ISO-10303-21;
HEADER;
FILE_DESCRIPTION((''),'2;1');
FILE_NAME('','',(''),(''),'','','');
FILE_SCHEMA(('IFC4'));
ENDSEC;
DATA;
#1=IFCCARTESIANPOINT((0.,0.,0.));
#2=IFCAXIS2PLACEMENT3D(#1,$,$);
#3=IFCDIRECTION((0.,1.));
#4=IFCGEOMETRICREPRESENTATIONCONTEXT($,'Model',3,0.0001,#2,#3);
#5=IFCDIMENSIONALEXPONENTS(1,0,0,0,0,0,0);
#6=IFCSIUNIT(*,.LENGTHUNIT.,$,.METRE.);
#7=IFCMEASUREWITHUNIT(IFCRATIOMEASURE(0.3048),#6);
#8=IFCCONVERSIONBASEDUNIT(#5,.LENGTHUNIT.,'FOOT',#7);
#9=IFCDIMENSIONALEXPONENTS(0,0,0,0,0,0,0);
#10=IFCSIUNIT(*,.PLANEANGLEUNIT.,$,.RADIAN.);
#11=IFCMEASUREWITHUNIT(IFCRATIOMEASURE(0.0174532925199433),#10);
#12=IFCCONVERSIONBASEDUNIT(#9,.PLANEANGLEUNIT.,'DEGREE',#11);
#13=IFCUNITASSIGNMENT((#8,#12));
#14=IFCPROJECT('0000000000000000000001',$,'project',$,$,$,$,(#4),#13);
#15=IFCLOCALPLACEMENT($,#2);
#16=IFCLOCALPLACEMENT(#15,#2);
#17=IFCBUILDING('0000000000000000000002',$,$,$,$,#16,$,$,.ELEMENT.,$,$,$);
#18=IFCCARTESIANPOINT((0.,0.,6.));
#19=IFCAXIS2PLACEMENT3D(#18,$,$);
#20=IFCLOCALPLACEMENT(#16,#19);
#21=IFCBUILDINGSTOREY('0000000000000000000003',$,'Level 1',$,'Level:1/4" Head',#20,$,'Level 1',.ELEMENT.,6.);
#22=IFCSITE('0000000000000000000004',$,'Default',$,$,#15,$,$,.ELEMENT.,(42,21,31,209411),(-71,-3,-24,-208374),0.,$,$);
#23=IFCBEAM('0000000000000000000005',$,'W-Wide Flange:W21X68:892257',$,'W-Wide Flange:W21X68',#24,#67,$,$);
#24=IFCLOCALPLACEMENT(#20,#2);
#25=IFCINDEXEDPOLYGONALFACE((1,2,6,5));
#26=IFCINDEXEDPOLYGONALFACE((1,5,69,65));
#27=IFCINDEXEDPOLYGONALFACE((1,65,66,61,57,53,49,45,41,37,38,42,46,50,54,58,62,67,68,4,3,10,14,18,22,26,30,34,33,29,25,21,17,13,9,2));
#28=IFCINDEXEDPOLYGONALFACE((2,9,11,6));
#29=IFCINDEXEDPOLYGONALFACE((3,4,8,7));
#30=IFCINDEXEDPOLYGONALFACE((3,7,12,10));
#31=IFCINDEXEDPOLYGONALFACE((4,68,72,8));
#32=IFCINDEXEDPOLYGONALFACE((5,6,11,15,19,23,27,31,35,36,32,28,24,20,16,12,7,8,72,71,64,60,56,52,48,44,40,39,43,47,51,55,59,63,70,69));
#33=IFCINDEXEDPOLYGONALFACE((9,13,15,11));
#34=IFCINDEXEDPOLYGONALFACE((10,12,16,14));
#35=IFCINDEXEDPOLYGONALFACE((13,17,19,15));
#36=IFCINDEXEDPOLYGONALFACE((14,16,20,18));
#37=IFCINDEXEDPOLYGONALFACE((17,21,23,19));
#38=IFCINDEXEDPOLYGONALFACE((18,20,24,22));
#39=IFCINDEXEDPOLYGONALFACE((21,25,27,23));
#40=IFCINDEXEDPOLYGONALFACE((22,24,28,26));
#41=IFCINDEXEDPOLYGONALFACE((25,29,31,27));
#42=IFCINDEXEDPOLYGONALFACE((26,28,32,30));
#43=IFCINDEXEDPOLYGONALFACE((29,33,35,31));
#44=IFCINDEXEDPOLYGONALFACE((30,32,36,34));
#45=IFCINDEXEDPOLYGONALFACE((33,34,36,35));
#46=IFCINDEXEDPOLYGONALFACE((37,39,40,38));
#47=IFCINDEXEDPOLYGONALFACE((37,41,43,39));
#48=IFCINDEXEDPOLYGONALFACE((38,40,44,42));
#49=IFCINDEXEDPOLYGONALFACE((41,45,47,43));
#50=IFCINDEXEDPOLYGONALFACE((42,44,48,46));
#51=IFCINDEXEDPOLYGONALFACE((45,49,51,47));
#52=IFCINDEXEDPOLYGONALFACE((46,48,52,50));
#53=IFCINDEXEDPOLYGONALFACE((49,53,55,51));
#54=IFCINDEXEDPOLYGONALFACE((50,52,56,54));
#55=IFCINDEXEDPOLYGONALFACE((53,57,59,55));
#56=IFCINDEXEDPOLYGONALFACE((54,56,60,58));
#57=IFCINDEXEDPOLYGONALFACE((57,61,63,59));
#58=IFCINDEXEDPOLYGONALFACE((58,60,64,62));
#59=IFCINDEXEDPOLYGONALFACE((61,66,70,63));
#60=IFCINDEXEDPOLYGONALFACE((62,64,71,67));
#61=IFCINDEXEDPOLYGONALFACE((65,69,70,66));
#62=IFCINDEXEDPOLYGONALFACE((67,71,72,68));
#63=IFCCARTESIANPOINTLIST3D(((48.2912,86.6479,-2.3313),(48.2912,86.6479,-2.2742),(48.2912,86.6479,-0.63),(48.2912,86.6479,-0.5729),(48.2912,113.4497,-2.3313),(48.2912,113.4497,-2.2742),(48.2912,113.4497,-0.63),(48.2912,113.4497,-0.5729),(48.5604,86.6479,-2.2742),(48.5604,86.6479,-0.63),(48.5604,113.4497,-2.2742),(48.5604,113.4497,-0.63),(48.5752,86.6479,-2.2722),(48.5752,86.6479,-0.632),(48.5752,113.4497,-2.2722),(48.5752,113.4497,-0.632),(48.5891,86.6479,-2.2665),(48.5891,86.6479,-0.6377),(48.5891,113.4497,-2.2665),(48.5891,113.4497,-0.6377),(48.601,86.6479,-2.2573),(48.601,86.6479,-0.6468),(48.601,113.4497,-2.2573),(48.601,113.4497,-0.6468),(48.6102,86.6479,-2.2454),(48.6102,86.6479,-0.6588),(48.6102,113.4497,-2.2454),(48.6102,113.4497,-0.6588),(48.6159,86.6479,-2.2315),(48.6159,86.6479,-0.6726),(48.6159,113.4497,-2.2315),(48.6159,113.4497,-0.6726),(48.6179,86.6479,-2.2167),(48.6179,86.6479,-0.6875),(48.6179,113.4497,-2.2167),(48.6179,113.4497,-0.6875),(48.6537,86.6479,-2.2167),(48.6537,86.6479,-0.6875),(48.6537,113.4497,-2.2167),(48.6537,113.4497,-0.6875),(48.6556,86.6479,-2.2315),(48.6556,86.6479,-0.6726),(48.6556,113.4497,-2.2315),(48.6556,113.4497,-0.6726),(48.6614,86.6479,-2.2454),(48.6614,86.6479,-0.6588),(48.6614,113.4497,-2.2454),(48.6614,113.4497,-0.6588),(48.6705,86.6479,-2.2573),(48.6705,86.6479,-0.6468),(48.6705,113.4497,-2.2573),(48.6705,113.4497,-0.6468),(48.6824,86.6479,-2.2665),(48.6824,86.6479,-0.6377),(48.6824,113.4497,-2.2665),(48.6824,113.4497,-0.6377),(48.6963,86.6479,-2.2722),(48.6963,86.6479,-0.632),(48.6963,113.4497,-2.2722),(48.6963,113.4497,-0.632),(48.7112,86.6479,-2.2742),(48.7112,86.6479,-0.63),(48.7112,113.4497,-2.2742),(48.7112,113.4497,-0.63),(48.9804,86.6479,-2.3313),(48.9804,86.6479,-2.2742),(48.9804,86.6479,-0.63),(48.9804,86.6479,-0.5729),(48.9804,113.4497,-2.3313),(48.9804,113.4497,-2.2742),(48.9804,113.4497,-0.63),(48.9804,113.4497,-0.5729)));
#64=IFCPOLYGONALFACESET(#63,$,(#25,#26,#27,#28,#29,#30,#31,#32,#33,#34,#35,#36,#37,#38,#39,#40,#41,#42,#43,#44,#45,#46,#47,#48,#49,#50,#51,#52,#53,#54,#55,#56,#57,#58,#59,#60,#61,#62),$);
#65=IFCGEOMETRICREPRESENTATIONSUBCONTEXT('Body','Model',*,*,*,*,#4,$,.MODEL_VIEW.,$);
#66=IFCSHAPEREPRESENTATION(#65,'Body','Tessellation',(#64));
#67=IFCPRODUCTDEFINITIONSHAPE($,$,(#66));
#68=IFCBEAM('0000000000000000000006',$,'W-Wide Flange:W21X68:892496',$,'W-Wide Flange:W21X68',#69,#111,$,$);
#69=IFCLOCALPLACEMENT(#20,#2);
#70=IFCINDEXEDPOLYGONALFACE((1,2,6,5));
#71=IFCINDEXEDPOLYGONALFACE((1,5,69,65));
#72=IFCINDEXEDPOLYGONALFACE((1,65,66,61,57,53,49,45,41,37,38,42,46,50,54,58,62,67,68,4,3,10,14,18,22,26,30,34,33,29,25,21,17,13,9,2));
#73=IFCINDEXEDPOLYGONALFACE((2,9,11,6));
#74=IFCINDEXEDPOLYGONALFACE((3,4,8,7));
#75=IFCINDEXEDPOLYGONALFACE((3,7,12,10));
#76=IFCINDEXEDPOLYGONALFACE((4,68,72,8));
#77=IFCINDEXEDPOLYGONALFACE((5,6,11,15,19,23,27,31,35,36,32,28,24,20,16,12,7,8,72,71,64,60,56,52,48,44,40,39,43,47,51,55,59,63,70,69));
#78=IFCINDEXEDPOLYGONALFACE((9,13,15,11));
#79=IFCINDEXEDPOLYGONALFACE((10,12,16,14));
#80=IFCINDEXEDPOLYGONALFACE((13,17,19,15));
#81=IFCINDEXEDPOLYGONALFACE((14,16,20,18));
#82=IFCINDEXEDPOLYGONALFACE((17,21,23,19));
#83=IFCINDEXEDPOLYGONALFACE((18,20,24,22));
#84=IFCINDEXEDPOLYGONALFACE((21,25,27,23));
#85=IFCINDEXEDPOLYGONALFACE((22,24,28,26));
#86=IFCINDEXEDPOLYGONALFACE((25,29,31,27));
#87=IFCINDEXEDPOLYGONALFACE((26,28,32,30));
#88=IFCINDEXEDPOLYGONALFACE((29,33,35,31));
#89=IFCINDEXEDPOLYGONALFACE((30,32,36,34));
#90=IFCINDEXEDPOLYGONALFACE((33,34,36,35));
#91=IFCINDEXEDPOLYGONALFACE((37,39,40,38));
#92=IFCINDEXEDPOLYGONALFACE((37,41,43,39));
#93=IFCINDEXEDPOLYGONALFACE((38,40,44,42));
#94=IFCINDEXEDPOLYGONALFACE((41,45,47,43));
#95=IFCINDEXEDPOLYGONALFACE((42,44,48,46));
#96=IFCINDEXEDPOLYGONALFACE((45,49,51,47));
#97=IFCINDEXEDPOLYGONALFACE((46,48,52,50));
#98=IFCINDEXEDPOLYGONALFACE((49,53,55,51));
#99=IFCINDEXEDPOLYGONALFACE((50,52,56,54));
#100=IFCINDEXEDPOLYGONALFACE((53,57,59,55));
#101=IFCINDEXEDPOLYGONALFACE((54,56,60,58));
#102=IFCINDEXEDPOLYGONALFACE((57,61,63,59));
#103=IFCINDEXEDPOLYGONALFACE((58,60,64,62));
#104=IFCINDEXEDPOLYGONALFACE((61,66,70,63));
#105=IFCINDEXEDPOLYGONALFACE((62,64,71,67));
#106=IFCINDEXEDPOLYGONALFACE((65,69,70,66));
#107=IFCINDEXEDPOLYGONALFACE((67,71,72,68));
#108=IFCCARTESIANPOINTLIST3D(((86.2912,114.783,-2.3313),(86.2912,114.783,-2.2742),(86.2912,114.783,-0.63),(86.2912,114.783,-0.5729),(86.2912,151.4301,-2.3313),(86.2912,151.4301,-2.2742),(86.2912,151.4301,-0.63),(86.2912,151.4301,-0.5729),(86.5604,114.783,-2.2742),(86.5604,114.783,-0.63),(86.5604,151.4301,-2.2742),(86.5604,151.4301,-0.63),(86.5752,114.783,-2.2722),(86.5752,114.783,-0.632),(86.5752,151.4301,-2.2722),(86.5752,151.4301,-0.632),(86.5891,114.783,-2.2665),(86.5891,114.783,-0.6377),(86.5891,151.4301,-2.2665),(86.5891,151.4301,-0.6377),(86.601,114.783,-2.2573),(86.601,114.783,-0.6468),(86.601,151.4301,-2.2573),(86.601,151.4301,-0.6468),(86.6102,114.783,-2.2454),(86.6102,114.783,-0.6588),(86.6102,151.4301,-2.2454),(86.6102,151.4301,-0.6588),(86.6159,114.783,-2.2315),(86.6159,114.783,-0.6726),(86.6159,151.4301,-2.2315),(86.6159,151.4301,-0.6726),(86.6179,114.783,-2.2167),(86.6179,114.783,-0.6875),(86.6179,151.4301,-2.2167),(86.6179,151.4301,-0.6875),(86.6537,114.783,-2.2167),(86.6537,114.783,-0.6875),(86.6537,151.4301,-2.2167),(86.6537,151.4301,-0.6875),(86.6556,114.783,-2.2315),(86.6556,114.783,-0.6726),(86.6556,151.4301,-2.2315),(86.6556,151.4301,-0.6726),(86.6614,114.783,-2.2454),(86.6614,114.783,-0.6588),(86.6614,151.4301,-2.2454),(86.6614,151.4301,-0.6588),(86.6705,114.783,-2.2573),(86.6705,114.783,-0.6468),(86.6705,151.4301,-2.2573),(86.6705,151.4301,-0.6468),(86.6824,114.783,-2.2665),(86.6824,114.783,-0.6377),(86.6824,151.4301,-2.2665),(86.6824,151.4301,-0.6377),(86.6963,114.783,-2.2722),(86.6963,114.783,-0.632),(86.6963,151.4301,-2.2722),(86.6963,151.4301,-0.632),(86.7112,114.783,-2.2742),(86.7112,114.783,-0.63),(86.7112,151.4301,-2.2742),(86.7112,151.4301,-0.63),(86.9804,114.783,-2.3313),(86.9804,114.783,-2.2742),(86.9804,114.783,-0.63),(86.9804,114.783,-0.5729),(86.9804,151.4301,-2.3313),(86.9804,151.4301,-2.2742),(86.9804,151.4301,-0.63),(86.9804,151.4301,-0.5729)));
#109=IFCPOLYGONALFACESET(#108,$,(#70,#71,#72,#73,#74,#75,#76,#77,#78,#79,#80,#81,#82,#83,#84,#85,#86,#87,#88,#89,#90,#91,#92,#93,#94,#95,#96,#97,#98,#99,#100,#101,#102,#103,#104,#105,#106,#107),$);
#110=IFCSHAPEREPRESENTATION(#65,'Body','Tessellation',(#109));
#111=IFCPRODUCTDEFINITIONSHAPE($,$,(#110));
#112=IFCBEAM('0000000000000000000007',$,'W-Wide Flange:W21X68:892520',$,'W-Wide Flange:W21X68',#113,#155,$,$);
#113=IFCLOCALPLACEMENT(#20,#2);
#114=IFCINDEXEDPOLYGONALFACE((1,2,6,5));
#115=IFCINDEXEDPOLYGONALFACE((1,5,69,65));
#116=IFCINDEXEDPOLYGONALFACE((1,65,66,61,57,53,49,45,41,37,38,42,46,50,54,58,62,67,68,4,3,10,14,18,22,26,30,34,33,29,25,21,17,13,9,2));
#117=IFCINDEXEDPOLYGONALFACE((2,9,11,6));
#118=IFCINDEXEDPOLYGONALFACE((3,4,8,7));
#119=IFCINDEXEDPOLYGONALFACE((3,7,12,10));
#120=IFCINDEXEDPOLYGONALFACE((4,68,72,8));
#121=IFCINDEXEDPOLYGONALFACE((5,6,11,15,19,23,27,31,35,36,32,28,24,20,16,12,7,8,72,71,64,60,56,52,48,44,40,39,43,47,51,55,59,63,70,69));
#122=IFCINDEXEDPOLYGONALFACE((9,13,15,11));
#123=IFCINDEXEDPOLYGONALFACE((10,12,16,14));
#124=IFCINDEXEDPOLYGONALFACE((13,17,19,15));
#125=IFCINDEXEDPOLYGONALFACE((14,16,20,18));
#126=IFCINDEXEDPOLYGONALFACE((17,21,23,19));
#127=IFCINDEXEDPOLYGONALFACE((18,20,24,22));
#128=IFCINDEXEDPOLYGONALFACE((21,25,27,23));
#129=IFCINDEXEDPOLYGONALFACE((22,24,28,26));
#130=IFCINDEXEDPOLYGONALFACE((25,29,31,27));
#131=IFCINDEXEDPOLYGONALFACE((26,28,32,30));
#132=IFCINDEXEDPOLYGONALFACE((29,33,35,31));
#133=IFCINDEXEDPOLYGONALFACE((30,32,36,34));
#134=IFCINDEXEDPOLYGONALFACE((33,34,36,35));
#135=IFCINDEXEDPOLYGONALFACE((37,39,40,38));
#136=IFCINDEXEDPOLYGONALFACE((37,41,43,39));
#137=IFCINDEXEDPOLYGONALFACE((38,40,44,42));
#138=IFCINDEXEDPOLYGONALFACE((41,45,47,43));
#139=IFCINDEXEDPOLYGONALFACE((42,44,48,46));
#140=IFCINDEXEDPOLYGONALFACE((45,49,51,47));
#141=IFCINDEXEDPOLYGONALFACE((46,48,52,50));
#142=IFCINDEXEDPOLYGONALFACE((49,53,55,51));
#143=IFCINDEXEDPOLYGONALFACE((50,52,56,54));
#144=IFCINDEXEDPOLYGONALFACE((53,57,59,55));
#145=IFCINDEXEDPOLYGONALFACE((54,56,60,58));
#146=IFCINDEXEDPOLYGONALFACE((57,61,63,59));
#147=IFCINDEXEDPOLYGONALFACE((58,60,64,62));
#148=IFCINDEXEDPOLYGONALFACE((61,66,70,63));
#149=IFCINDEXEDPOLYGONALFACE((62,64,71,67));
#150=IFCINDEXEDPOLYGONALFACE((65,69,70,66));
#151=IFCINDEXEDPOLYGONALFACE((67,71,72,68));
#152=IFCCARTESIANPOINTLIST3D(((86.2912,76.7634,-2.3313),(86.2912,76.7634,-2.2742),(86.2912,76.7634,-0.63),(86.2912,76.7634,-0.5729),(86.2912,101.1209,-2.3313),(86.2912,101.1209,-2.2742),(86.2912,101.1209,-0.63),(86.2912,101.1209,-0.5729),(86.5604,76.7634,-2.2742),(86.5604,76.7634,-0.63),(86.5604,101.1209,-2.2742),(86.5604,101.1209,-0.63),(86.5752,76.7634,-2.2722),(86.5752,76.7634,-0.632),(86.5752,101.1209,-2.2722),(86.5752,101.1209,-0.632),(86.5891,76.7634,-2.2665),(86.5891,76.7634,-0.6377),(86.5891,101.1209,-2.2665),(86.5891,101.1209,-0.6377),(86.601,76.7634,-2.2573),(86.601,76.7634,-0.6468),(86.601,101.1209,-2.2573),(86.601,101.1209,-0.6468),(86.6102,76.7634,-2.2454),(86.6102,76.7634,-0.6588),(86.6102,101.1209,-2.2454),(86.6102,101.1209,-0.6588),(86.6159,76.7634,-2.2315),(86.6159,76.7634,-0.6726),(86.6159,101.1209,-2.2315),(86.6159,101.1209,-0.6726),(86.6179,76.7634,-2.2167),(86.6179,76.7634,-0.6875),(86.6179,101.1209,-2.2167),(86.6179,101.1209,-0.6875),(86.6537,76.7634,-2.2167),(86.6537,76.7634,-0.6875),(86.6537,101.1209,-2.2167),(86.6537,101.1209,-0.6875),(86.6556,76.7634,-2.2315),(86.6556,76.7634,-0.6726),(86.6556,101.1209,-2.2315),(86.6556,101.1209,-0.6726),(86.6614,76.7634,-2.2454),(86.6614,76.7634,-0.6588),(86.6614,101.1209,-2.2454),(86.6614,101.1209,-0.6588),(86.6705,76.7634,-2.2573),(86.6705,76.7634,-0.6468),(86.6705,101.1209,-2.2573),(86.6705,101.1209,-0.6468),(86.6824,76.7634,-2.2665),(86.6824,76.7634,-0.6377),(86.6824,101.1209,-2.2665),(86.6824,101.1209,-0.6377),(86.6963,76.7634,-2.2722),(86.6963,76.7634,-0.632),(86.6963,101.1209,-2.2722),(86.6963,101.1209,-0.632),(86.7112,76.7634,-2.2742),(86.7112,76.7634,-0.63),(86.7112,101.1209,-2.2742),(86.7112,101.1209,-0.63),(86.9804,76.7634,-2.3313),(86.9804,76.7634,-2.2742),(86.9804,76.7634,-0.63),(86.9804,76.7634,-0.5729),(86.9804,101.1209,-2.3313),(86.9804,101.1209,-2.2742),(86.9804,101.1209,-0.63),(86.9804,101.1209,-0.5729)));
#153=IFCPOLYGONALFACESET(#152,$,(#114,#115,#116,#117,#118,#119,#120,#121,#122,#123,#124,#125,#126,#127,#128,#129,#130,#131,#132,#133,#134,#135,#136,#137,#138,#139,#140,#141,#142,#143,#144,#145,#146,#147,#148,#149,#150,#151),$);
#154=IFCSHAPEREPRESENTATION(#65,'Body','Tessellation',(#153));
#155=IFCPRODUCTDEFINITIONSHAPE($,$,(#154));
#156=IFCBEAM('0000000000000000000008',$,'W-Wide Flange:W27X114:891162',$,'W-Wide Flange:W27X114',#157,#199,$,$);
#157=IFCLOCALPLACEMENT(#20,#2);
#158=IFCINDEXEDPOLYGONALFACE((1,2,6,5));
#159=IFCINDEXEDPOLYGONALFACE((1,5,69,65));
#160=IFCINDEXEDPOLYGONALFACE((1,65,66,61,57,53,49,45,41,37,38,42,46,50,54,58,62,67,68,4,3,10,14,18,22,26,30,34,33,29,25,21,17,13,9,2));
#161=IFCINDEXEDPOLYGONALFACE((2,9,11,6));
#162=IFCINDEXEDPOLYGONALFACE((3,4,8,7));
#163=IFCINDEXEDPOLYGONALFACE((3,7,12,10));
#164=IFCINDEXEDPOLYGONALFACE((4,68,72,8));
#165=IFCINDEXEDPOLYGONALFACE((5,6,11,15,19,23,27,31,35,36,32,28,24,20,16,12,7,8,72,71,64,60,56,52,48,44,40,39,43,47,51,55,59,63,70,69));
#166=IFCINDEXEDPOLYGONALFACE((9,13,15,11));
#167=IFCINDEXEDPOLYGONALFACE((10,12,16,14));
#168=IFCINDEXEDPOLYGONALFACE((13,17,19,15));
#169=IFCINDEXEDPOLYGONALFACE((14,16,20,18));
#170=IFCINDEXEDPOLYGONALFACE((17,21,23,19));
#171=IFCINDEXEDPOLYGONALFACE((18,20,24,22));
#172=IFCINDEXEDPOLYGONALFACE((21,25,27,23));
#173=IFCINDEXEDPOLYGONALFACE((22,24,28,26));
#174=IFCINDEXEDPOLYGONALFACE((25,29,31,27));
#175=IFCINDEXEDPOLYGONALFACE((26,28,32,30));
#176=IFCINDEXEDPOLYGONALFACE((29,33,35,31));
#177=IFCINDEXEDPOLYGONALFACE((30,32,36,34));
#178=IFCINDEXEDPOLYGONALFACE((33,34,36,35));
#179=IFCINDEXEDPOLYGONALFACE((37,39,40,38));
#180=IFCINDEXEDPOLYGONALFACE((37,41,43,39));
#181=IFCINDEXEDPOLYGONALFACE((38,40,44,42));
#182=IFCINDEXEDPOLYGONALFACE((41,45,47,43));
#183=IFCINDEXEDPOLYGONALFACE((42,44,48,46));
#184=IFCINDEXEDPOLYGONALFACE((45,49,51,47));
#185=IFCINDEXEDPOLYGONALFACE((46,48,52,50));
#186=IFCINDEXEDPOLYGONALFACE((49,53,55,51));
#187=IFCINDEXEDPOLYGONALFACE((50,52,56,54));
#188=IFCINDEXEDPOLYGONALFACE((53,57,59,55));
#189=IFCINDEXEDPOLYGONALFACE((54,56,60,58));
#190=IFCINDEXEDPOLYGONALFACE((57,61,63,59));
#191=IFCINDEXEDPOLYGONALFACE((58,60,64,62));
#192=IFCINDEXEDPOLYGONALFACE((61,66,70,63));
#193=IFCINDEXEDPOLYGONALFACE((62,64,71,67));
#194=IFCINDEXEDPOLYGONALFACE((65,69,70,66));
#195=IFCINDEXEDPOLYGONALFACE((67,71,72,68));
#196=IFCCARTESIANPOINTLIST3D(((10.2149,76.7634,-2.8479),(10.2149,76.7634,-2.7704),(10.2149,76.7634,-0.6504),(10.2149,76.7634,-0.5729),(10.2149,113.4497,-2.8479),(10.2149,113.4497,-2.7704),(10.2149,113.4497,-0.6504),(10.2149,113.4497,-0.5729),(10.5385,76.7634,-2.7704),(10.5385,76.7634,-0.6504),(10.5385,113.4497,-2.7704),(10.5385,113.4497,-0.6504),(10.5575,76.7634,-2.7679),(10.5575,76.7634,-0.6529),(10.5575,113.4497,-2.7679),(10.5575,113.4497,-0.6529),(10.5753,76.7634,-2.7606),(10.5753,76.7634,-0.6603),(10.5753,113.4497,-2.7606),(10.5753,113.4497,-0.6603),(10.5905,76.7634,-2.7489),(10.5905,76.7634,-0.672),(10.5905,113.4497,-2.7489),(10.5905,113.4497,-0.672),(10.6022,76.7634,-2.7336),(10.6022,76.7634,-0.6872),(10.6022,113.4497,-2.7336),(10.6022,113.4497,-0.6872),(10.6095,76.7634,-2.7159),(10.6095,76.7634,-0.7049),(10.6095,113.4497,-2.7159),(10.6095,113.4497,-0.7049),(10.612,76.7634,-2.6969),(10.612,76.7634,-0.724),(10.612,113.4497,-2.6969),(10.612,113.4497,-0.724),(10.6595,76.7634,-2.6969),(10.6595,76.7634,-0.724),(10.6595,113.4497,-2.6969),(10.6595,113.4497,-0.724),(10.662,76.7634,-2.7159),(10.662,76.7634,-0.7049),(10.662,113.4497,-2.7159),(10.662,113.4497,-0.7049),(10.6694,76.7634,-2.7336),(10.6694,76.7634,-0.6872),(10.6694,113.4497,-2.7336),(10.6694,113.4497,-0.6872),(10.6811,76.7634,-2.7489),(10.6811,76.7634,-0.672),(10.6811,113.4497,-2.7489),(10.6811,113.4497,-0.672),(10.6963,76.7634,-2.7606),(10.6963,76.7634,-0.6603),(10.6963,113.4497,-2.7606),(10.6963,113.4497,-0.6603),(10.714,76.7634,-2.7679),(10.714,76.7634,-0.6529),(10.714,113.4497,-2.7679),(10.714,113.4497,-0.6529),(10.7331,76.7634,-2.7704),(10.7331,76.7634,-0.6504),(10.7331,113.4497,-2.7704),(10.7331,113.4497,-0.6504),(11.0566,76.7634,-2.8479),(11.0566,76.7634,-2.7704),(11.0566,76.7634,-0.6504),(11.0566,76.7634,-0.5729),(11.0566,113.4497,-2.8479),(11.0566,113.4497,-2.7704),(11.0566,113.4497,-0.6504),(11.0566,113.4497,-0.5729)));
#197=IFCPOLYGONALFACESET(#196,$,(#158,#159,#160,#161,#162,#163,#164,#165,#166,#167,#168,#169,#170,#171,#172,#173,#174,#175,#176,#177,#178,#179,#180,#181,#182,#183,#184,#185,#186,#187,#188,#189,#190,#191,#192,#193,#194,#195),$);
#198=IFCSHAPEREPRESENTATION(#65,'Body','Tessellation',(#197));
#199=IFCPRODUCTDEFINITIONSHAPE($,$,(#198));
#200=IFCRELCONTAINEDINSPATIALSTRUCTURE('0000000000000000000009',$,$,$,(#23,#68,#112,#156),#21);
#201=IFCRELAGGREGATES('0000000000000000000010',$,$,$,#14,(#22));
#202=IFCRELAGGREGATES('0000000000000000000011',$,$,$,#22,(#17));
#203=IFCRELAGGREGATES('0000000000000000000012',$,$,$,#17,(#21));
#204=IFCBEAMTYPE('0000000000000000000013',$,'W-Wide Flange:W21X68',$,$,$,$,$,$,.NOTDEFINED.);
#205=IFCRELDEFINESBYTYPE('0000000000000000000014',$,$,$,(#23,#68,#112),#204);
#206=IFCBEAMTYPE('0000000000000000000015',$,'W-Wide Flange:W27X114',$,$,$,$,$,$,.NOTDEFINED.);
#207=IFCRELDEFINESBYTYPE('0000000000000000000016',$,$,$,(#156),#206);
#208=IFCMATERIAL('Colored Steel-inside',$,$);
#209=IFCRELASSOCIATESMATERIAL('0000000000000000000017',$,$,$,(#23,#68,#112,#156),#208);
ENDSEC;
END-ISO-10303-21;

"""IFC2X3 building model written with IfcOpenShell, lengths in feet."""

from ifc_helpers import new_model, entity, si_unit, converted_unit, direction, frame, frame_2d, origin, place, context, subcontext, project, spatial, i_section, extrude, material, type_object, element, save


model = new_model("IFC2X3")

# Units and contexts
model_context = context("Model", 3, precision=0.0001, world=origin(), true_north=direction((0.0, 1.0)))
body_context = subcontext(model_context, "Body", "Model", "MODEL_VIEW")
ifc_project = project(units=[converted_unit("LENGTHUNIT", "FOOT", entity("IfcRatioMeasure", 0.3048), si_unit("LENGTHUNIT", "METRE"), dimensions=[1, 0, 0, 0, 0, 0, 0]), converted_unit("PLANEANGLEUNIT", "DEGREE", entity("IfcRatioMeasure", 0.0174532925199433), si_unit("PLANEANGLEUNIT", "RADIAN"), dimensions=[0, 0, 0, 0, 0, 0, 0])], contexts=[model_context])

# Site, building, storey
site_placement = place(None, origin())
site = spatial("IfcSite", under=ifc_project, at=site_placement, Name="Default", CompositionType="ELEMENT", RefLatitude=(42, 21, 31, 209411), RefLongitude=(-71, -3, -24, -208374), RefElevation=0.0)
building_placement = place(site_placement, origin())
building = spatial("IfcBuilding", under=site, at=building_placement, CompositionType="ELEMENT")
storey_placement = place(building_placement, frame((0.0, 0.0, 6.0)))
storey = spatial("IfcBuildingStorey", under=building, at=storey_placement, Name="Level 1", ObjectType="Level:1/4\" Head", LongName="Level 1", CompositionType="ELEMENT", Elevation=6.0)

# Shared definitions
ifc_material_1 = material(Name="Colored Steel-inside")

# Beams
beam_type_1 = type_object("IfcBeamType", Name="W-Wide Flange:W21X68", PredefinedType="NOTDEFINED")
beam_1_placement = place(storey_placement, frame((48.6358, 114.0968, 0.0), z_axis=(0.0, 0.0, 1.0), x_axis=(0.0, -1.0, 0.0)))
element("IfcBeam", 1, at=beam_1_placement, inside=storey, type_object=beam_type_1, material=ifc_material_1, Name="W-Wide Flange:W21X68:892257", ObjectType="W-Wide Flange:W21X68", context=body_context, shape_type="SweptSolid", body=[
    extrude(i_section(OverallWidth=0.6892, OverallDepth=1.7583, WebThickness=0.0358, FlangeThickness=0.0571, FilletRadius=0.0575, at=frame_2d((0.0, 0.0), x_axis=(0.0, 1.0))), frame((0.6471, 0.0, -1.4521), z_axis=(1.0, 0.0, 0.0), x_axis=(0.0, 0.0, -1.0)), (0.0, 0.0, 1.0), 26.8018),
])
beam_2_placement = place(storey_placement, frame((86.6358, 152.0968, 0.0), z_axis=(0.0, 0.0, 1.0), x_axis=(0.0, -1.0, 0.0)))
element("IfcBeam", 2, at=beam_2_placement, inside=storey, type_object=beam_type_1, material=ifc_material_1, Name="W-Wide Flange:W21X68:892496", ObjectType="W-Wide Flange:W21X68", context=body_context, shape_type="SweptSolid", body=[
    extrude(i_section(OverallWidth=0.6892, OverallDepth=1.7583, WebThickness=0.0358, FlangeThickness=0.0571, FilletRadius=0.0575, at=frame_2d((0.0, 0.0), x_axis=(0.0, 1.0))), frame((0.6667, 0.0, -1.4521), z_axis=(1.0, 0.0, 0.0), x_axis=(0.0, 0.0, -1.0)), (0.0, 0.0, 1.0), 36.6471),
])
beam_3_placement = place(storey_placement, frame((86.6358, 101.4301, 0.0), z_axis=(0.0, 0.0, 1.0), x_axis=(0.0, -1.0, 0.0)))
element("IfcBeam", 3, at=beam_3_placement, inside=storey, type_object=beam_type_1, material=ifc_material_1, Name="W-Wide Flange:W21X68:892520", ObjectType="W-Wide Flange:W21X68", context=body_context, shape_type="SweptSolid", body=[
    extrude(i_section(OverallWidth=0.6892, OverallDepth=1.7583, WebThickness=0.0358, FlangeThickness=0.0571, FilletRadius=0.0575, at=frame_2d((0.0, 0.0), x_axis=(0.0, 1.0))), frame((0.3092, 0.0, -1.4521), z_axis=(1.0, 0.0, 0.0), x_axis=(0.0, 0.0, -1.0)), (0.0, 0.0, 1.0), 24.3575),
])
beam_type_2 = type_object("IfcBeamType", Name="W-Wide Flange:W27X114", PredefinedType="NOTDEFINED")
beam_4_placement = place(storey_placement, frame((10.6358, 114.0968, 0.0), z_axis=(0.0, 0.0, 1.0), x_axis=(0.0, -1.0, 0.0)))
element("IfcBeam", 4, at=beam_4_placement, inside=storey, type_object=beam_type_2, material=ifc_material_1, Name="W-Wide Flange:W27X114:891162", ObjectType="W-Wide Flange:W27X114", context=body_context, shape_type="SweptSolid", body=[
    extrude(i_section(OverallWidth=0.8417, OverallDepth=2.275, WebThickness=0.0475, FlangeThickness=0.0775, FilletRadius=0.0735, at=frame_2d((0.0, 0.0), x_axis=(0.0, 1.0))), frame((0.6471, 0.0, -1.7104), z_axis=(1.0, 0.0, 0.0), x_axis=(0.0, 0.0, -1.0)), (0.0, 0.0, 1.0), 36.6863),
])

save(model, "model.ifc")
